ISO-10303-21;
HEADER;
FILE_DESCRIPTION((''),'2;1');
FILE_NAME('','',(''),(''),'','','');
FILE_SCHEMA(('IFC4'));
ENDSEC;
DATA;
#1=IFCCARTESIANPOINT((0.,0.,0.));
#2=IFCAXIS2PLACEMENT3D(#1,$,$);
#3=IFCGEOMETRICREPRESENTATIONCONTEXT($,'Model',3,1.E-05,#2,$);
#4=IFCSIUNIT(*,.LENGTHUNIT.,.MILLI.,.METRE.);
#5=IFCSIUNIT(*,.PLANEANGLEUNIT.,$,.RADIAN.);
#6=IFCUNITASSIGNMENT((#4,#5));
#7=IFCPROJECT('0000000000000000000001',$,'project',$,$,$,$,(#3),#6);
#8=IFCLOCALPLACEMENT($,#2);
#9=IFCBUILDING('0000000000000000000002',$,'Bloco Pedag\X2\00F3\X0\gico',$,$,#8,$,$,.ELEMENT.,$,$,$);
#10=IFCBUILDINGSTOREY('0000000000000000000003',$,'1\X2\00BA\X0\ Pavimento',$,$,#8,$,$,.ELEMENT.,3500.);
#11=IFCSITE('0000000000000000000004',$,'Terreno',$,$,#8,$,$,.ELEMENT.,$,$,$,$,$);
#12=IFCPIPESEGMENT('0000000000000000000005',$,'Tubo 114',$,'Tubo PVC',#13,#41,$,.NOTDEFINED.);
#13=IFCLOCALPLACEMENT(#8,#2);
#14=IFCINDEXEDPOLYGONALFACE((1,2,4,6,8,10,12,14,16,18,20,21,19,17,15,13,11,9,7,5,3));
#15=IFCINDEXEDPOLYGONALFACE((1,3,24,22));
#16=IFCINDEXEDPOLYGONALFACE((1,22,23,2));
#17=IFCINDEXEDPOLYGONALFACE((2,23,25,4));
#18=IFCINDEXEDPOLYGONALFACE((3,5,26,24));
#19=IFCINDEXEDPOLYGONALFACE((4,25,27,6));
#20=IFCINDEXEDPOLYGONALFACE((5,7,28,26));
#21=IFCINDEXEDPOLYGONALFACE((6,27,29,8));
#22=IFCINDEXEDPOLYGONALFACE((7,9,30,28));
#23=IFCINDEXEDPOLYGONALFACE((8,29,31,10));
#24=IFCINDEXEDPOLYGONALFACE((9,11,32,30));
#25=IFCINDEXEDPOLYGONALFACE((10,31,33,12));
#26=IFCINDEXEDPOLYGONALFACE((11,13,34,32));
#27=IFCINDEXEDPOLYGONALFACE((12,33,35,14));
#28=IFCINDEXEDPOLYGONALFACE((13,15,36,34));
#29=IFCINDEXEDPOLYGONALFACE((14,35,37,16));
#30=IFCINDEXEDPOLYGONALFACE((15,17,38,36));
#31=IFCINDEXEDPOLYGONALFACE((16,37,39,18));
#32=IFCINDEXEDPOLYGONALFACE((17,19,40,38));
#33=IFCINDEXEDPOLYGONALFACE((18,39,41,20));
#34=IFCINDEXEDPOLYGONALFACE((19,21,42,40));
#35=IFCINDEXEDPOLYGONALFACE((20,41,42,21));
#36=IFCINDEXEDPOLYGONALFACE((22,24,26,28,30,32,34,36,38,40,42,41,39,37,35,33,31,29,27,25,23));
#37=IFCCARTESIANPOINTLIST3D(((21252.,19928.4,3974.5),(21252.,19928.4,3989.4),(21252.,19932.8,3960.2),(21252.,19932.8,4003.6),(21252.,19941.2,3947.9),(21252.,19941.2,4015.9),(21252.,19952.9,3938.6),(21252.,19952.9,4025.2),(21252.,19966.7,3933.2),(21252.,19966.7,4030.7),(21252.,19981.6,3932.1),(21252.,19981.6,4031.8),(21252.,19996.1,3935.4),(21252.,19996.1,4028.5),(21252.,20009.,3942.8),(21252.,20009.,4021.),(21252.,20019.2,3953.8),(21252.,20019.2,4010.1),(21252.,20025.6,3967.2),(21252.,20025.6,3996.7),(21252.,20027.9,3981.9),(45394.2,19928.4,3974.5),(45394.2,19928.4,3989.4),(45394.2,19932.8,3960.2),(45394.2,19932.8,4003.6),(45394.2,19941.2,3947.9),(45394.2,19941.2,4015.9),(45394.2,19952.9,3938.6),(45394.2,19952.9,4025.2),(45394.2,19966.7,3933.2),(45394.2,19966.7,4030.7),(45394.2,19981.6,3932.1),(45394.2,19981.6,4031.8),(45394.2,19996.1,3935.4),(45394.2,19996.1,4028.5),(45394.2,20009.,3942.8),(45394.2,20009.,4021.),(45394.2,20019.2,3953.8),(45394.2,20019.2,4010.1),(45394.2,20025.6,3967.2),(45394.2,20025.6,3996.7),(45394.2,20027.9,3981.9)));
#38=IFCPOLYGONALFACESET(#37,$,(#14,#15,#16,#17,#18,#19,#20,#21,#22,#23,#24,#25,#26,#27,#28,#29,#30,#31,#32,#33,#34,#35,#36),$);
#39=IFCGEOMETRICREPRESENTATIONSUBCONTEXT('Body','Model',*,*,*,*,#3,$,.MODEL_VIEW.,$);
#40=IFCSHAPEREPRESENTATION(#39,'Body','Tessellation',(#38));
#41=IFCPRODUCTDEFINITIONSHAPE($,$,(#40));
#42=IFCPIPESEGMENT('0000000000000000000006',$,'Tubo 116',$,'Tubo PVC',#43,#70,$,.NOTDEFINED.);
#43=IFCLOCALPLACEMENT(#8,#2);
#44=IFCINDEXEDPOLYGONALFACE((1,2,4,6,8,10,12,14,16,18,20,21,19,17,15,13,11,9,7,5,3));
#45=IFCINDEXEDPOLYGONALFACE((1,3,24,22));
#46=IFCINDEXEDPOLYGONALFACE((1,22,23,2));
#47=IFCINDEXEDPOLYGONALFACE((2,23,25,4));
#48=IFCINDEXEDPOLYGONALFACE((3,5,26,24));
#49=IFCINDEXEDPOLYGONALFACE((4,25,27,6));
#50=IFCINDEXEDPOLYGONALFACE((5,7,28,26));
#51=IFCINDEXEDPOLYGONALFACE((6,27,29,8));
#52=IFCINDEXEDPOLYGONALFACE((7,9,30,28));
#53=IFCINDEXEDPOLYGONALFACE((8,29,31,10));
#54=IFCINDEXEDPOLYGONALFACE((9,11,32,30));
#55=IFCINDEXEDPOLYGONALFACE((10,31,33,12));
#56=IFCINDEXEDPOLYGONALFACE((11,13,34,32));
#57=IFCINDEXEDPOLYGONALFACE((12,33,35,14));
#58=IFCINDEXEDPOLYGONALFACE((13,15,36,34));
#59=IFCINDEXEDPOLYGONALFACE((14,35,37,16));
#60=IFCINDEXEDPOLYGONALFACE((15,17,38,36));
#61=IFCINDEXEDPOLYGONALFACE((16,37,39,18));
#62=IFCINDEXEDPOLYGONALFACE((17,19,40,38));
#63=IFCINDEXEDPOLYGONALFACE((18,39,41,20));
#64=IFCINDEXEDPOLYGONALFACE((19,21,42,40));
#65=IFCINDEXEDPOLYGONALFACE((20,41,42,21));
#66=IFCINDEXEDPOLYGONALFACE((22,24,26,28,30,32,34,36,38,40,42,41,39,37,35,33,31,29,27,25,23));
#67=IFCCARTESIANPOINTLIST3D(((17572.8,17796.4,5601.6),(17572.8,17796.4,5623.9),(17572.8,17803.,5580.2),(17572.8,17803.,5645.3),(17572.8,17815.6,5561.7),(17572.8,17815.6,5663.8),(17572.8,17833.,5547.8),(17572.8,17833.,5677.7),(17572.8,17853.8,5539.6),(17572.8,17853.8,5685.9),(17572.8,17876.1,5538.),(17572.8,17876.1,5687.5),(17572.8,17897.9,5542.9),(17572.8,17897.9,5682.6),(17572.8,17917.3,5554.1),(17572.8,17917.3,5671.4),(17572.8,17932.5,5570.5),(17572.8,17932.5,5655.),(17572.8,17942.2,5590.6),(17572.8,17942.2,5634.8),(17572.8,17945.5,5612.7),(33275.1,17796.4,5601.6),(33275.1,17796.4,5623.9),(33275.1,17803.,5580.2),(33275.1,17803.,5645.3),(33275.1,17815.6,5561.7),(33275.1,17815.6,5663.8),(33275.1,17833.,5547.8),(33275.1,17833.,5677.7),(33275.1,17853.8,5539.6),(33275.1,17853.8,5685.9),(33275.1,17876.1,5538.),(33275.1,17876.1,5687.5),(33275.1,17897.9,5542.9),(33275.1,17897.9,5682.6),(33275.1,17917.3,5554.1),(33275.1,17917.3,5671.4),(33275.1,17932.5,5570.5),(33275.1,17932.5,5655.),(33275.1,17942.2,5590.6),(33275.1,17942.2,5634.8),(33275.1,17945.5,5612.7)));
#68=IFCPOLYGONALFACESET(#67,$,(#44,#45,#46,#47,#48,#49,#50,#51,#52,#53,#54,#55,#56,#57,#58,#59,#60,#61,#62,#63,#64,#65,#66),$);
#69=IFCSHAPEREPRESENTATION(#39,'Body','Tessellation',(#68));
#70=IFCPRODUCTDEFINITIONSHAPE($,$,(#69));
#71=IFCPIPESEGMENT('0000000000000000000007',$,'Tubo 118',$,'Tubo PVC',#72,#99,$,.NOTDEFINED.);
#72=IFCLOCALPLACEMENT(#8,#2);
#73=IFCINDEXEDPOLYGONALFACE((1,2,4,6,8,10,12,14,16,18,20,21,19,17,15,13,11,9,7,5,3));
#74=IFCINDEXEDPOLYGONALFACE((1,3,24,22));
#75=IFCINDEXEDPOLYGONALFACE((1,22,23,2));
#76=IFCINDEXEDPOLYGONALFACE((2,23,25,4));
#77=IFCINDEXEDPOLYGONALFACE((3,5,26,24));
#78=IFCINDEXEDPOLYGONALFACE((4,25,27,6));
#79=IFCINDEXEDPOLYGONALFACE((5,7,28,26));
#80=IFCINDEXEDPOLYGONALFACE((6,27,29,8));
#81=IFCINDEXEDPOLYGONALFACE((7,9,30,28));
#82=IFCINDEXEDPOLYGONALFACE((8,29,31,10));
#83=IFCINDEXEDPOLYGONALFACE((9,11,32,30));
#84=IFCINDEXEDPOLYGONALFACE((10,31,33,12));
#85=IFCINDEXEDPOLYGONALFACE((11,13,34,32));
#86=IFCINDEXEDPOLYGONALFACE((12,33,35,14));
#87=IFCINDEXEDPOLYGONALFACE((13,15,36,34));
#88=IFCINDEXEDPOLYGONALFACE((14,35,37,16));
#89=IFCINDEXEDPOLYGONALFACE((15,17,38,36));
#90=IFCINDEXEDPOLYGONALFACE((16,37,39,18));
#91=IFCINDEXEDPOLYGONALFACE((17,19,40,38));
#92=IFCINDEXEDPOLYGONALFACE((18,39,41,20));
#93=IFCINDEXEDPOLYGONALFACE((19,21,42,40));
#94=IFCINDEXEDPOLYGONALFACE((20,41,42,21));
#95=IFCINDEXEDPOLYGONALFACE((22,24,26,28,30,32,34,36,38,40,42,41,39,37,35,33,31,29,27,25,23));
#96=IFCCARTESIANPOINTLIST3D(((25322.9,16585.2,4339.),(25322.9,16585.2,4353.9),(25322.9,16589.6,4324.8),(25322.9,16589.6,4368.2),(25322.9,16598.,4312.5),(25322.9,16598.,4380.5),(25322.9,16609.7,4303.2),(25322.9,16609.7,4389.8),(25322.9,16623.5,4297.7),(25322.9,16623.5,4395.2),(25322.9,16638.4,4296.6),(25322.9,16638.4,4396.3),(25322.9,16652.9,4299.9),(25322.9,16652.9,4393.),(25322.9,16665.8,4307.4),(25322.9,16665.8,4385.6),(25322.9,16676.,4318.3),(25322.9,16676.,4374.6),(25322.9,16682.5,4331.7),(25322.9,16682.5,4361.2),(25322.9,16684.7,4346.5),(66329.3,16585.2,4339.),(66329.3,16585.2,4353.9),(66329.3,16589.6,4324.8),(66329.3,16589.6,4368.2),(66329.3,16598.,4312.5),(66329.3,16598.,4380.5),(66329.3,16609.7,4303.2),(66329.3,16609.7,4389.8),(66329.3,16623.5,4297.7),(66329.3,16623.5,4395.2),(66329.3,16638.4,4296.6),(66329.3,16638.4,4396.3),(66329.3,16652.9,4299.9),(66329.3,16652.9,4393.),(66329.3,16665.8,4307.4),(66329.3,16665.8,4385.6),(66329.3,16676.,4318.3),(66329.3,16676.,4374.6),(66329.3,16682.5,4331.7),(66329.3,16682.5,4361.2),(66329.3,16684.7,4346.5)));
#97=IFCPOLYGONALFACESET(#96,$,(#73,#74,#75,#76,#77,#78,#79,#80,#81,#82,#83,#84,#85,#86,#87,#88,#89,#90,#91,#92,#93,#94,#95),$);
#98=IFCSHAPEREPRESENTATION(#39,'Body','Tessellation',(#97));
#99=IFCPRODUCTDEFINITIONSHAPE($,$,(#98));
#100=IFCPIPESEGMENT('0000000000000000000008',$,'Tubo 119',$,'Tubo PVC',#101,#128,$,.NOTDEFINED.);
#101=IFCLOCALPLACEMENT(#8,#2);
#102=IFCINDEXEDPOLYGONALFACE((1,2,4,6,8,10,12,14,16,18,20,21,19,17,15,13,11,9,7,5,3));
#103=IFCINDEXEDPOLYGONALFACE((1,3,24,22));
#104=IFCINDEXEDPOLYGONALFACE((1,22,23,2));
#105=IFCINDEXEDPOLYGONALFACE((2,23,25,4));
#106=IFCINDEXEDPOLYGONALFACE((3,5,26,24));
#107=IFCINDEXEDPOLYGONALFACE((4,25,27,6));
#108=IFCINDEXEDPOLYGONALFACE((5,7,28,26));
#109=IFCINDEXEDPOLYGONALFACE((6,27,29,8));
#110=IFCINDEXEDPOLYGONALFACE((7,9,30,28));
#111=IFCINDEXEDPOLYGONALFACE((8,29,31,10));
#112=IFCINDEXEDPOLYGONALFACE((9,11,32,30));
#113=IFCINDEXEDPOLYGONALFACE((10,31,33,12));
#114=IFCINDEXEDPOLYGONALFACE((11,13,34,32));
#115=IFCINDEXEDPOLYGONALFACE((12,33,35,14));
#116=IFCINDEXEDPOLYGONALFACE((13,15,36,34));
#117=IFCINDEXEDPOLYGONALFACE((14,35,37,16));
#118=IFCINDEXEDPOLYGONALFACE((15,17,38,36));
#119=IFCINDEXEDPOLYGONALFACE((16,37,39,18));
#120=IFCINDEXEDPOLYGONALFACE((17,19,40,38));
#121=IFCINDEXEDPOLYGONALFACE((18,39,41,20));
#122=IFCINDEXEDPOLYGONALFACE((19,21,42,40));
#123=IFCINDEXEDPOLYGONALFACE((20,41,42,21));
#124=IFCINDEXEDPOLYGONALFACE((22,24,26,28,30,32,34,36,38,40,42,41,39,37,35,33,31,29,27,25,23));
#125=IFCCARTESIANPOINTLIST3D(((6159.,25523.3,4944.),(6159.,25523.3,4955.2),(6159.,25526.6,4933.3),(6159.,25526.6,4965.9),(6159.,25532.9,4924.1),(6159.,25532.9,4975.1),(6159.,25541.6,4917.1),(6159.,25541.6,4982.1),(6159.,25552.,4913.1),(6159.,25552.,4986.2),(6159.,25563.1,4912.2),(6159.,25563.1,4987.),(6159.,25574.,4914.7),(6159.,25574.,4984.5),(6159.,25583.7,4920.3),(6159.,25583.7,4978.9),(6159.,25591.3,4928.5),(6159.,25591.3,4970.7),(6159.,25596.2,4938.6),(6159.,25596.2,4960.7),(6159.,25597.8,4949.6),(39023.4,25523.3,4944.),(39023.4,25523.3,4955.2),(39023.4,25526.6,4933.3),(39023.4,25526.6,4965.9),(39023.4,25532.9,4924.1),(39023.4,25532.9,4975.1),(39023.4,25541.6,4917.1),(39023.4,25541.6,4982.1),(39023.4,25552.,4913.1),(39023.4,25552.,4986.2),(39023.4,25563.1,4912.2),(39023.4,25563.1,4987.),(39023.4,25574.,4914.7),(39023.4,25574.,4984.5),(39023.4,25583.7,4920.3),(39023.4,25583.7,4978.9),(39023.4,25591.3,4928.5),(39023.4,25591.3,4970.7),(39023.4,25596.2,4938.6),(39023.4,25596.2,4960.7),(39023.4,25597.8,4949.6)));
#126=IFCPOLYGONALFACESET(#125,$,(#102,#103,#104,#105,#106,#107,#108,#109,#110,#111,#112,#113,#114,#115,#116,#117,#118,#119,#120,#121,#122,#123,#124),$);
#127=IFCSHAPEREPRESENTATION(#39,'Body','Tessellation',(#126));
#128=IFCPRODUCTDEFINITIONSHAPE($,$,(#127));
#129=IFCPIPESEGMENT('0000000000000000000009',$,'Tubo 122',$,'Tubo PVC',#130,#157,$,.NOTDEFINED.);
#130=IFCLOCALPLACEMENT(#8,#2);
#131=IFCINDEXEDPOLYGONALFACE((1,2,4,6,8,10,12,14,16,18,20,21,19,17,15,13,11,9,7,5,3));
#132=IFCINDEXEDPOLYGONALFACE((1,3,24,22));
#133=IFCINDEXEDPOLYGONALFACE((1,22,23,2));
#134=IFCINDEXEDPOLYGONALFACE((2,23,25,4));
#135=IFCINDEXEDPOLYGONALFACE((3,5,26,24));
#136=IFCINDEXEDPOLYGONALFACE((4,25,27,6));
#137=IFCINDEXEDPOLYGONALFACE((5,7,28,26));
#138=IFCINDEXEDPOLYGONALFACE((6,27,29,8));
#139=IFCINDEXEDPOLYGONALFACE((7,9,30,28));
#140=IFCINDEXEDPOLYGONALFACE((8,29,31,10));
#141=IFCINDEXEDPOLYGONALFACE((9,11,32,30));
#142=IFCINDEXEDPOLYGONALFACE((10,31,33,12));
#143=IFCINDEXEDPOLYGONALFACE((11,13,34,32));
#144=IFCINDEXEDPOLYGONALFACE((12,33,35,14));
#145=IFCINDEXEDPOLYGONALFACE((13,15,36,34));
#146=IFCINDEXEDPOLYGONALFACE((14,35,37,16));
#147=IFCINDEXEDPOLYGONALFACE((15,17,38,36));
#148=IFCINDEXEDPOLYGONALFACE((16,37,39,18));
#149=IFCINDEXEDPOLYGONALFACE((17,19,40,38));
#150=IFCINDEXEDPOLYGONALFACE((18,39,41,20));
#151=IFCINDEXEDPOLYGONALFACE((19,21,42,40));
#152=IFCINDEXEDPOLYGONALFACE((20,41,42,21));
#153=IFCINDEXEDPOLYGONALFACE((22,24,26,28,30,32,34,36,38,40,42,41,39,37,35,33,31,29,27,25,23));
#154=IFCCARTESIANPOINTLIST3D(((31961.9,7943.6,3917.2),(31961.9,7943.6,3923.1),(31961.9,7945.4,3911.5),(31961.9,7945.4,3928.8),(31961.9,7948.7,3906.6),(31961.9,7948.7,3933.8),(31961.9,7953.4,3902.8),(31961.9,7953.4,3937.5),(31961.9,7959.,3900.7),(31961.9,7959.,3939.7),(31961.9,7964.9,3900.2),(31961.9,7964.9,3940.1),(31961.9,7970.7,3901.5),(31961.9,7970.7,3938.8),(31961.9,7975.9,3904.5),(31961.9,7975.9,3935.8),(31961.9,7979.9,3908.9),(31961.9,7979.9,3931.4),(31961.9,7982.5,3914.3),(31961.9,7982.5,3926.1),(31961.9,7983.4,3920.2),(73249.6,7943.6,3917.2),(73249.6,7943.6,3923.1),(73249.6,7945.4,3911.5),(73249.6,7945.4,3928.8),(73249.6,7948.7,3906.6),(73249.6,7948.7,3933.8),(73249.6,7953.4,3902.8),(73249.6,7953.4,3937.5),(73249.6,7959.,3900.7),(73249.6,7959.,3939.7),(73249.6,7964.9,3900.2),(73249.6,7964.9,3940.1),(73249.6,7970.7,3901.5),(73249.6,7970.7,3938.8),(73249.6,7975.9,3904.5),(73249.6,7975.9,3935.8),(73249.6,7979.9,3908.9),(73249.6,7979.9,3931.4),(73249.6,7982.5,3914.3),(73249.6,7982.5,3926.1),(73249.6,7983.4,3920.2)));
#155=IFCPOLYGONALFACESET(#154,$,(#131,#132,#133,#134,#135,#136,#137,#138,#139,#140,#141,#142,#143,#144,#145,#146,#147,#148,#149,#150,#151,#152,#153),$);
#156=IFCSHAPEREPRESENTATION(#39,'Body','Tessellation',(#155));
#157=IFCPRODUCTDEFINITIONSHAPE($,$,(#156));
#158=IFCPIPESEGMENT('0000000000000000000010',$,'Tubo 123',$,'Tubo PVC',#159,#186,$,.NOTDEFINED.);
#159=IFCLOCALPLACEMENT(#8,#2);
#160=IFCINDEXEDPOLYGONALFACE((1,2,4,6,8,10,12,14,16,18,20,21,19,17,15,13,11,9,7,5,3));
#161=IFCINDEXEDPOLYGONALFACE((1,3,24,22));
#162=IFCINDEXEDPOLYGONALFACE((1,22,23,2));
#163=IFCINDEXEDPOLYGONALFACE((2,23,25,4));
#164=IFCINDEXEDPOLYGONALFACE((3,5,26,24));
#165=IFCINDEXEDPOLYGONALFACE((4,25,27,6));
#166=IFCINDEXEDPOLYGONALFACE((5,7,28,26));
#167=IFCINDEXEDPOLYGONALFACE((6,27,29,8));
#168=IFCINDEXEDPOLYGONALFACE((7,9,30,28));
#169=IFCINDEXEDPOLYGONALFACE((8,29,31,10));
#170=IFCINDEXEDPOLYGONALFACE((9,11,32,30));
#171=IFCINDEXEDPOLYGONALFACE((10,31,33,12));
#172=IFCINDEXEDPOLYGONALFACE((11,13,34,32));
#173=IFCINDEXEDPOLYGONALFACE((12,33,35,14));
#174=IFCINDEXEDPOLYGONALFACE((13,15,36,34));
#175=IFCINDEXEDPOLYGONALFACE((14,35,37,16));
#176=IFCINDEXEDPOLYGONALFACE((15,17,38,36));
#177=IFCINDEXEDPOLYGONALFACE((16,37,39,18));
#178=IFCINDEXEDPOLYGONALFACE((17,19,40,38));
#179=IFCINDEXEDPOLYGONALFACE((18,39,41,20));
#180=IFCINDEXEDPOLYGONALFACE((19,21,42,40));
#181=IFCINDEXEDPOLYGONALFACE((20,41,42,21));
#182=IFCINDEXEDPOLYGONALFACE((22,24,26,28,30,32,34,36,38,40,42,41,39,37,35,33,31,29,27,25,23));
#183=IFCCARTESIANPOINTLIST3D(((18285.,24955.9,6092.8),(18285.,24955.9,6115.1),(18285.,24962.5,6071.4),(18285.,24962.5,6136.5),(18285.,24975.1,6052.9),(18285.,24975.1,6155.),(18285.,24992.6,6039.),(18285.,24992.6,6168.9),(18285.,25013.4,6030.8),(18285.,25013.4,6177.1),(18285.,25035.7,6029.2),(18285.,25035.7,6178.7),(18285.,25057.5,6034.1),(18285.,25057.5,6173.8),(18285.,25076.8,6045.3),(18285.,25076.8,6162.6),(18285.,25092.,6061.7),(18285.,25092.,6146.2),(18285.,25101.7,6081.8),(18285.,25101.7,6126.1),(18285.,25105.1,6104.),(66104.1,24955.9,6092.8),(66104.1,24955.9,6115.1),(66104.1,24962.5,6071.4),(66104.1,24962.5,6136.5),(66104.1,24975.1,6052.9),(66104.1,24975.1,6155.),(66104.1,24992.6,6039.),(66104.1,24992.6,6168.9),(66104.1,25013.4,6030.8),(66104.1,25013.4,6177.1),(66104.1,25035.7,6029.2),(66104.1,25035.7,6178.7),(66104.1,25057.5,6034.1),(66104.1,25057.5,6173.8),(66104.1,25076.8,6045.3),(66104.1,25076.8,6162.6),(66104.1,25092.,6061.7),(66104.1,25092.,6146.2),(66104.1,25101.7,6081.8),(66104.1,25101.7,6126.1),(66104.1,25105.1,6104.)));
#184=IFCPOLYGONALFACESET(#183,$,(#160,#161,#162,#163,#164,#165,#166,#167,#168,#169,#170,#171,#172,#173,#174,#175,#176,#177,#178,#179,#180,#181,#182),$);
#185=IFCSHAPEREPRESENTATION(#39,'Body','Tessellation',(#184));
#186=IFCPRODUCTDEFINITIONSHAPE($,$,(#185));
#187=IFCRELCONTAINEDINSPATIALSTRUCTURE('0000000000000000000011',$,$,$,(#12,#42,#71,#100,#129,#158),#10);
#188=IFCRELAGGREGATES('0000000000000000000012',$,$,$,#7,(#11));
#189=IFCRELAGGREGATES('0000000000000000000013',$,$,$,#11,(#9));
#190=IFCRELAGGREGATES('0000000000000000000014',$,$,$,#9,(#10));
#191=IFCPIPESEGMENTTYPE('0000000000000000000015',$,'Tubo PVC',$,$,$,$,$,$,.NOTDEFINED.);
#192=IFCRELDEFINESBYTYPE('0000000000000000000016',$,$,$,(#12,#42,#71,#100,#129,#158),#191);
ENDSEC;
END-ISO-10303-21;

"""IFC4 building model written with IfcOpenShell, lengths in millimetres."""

from ifc_helpers import new_model, si_unit, frame, origin, origin_2d, place, context, subcontext, project, spatial, circle, extrude, type_object, element, save


model = new_model("IFC4")

# Units and contexts
model_context = context("Model", 3, precision=1e-05, world=origin())
body_context = subcontext(model_context, "Body", "Model", "MODEL_VIEW")
ifc_project = project(units=[si_unit("LENGTHUNIT", "METRE", prefix="MILLI"), si_unit("PLANEANGLEUNIT", "RADIAN")], contexts=[model_context])

# Site, building, storey
placement = place(None, origin())
site = spatial("IfcSite", under=ifc_project, at=placement, Name="Terreno", CompositionType="ELEMENT")
building = spatial("IfcBuilding", under=site, at=placement, Name="Bloco Pedagógico", CompositionType="ELEMENT")
storey = spatial("IfcBuildingStorey", under=building, at=placement, Name="1º Pavimento", CompositionType="ELEMENT", Elevation=3500.0)

# Pipe segments
pipe_segment_type = type_object("IfcPipeSegmentType", Name="Tubo PVC", PredefinedType="NOTDEFINED")
pipe_segment_1_placement = place(None, frame((21252.0, 19977.9, 3981.9), z_axis=(1.0, 0.0, 0.0), x_axis=(0.0, 1.0, 0.0)))
element("IfcPipeSegment", 1, at=pipe_segment_1_placement, inside=storey, type_object=pipe_segment_type, Name="Tubo 114", ObjectType="Tubo PVC", PredefinedType="NOTDEFINED", context=body_context, shape_type="SweptSolid", body=[
    extrude(circle(Radius=50.0, at=origin_2d()), None, (0.0, 0.0, 1.0), 24142.2),
])
pipe_segment_2_placement = place(None, frame((17572.8, 17870.5, 5612.7), z_axis=(1.0, 0.0, 0.0), x_axis=(0.0, 1.0, 0.0)))
element("IfcPipeSegment", 2, at=pipe_segment_2_placement, inside=storey, type_object=pipe_segment_type, Name="Tubo 116", ObjectType="Tubo PVC", PredefinedType="NOTDEFINED", context=body_context, shape_type="SweptSolid", body=[
    extrude(circle(Radius=75.0, at=origin_2d()), None, (0.0, 0.0, 1.0), 15702.2),
])
pipe_segment_3_placement = place(None, frame((25322.9, 16634.7, 4346.5), z_axis=(1.0, 0.0, 0.0), x_axis=(0.0, 1.0, 0.0)))
element("IfcPipeSegment", 3, at=pipe_segment_3_placement, inside=storey, type_object=pipe_segment_type, Name="Tubo 118", ObjectType="Tubo PVC", PredefinedType="NOTDEFINED", context=body_context, shape_type="SweptSolid", body=[
    extrude(circle(Radius=50.0, at=origin_2d()), None, (0.0, 0.0, 1.0), 41006.4),
])
pipe_segment_4_placement = place(None, frame((6159.0, 25560.3, 4949.6), z_axis=(1.0, 0.0, 0.0), x_axis=(0.0, 1.0, 0.0)))
element("IfcPipeSegment", 4, at=pipe_segment_4_placement, inside=storey, type_object=pipe_segment_type, Name="Tubo 119", ObjectType="Tubo PVC", PredefinedType="NOTDEFINED", context=body_context, shape_type="SweptSolid", body=[
    extrude(circle(Radius=37.5, at=origin_2d()), None, (0.0, 0.0, 1.0), 32864.4),
])
pipe_segment_5_placement = place(None, frame((31961.9, 7963.4, 3920.2), z_axis=(1.0, 0.0, 0.0), x_axis=(0.0, 1.0, 0.0)))
element("IfcPipeSegment", 5, at=pipe_segment_5_placement, inside=storey, type_object=pipe_segment_type, Name="Tubo 122", ObjectType="Tubo PVC", PredefinedType="NOTDEFINED", context=body_context, shape_type="SweptSolid", body=[
    extrude(circle(Radius=20.0, at=origin_2d()), None, (0.0, 0.0, 1.0), 41287.7),
])
pipe_segment_6_placement = place(None, frame((18285.0, 25030.1, 6104.0), z_axis=(1.0, 0.0, 0.0), x_axis=(0.0, 1.0, 0.0)))
element("IfcPipeSegment", 6, at=pipe_segment_6_placement, inside=storey, type_object=pipe_segment_type, Name="Tubo 123", ObjectType="Tubo PVC", PredefinedType="NOTDEFINED", context=body_context, shape_type="SweptSolid", body=[
    extrude(circle(Radius=75.0, at=origin_2d()), None, (0.0, 0.0, 1.0), 47819.1),
])

save(model, "model.ifc")
